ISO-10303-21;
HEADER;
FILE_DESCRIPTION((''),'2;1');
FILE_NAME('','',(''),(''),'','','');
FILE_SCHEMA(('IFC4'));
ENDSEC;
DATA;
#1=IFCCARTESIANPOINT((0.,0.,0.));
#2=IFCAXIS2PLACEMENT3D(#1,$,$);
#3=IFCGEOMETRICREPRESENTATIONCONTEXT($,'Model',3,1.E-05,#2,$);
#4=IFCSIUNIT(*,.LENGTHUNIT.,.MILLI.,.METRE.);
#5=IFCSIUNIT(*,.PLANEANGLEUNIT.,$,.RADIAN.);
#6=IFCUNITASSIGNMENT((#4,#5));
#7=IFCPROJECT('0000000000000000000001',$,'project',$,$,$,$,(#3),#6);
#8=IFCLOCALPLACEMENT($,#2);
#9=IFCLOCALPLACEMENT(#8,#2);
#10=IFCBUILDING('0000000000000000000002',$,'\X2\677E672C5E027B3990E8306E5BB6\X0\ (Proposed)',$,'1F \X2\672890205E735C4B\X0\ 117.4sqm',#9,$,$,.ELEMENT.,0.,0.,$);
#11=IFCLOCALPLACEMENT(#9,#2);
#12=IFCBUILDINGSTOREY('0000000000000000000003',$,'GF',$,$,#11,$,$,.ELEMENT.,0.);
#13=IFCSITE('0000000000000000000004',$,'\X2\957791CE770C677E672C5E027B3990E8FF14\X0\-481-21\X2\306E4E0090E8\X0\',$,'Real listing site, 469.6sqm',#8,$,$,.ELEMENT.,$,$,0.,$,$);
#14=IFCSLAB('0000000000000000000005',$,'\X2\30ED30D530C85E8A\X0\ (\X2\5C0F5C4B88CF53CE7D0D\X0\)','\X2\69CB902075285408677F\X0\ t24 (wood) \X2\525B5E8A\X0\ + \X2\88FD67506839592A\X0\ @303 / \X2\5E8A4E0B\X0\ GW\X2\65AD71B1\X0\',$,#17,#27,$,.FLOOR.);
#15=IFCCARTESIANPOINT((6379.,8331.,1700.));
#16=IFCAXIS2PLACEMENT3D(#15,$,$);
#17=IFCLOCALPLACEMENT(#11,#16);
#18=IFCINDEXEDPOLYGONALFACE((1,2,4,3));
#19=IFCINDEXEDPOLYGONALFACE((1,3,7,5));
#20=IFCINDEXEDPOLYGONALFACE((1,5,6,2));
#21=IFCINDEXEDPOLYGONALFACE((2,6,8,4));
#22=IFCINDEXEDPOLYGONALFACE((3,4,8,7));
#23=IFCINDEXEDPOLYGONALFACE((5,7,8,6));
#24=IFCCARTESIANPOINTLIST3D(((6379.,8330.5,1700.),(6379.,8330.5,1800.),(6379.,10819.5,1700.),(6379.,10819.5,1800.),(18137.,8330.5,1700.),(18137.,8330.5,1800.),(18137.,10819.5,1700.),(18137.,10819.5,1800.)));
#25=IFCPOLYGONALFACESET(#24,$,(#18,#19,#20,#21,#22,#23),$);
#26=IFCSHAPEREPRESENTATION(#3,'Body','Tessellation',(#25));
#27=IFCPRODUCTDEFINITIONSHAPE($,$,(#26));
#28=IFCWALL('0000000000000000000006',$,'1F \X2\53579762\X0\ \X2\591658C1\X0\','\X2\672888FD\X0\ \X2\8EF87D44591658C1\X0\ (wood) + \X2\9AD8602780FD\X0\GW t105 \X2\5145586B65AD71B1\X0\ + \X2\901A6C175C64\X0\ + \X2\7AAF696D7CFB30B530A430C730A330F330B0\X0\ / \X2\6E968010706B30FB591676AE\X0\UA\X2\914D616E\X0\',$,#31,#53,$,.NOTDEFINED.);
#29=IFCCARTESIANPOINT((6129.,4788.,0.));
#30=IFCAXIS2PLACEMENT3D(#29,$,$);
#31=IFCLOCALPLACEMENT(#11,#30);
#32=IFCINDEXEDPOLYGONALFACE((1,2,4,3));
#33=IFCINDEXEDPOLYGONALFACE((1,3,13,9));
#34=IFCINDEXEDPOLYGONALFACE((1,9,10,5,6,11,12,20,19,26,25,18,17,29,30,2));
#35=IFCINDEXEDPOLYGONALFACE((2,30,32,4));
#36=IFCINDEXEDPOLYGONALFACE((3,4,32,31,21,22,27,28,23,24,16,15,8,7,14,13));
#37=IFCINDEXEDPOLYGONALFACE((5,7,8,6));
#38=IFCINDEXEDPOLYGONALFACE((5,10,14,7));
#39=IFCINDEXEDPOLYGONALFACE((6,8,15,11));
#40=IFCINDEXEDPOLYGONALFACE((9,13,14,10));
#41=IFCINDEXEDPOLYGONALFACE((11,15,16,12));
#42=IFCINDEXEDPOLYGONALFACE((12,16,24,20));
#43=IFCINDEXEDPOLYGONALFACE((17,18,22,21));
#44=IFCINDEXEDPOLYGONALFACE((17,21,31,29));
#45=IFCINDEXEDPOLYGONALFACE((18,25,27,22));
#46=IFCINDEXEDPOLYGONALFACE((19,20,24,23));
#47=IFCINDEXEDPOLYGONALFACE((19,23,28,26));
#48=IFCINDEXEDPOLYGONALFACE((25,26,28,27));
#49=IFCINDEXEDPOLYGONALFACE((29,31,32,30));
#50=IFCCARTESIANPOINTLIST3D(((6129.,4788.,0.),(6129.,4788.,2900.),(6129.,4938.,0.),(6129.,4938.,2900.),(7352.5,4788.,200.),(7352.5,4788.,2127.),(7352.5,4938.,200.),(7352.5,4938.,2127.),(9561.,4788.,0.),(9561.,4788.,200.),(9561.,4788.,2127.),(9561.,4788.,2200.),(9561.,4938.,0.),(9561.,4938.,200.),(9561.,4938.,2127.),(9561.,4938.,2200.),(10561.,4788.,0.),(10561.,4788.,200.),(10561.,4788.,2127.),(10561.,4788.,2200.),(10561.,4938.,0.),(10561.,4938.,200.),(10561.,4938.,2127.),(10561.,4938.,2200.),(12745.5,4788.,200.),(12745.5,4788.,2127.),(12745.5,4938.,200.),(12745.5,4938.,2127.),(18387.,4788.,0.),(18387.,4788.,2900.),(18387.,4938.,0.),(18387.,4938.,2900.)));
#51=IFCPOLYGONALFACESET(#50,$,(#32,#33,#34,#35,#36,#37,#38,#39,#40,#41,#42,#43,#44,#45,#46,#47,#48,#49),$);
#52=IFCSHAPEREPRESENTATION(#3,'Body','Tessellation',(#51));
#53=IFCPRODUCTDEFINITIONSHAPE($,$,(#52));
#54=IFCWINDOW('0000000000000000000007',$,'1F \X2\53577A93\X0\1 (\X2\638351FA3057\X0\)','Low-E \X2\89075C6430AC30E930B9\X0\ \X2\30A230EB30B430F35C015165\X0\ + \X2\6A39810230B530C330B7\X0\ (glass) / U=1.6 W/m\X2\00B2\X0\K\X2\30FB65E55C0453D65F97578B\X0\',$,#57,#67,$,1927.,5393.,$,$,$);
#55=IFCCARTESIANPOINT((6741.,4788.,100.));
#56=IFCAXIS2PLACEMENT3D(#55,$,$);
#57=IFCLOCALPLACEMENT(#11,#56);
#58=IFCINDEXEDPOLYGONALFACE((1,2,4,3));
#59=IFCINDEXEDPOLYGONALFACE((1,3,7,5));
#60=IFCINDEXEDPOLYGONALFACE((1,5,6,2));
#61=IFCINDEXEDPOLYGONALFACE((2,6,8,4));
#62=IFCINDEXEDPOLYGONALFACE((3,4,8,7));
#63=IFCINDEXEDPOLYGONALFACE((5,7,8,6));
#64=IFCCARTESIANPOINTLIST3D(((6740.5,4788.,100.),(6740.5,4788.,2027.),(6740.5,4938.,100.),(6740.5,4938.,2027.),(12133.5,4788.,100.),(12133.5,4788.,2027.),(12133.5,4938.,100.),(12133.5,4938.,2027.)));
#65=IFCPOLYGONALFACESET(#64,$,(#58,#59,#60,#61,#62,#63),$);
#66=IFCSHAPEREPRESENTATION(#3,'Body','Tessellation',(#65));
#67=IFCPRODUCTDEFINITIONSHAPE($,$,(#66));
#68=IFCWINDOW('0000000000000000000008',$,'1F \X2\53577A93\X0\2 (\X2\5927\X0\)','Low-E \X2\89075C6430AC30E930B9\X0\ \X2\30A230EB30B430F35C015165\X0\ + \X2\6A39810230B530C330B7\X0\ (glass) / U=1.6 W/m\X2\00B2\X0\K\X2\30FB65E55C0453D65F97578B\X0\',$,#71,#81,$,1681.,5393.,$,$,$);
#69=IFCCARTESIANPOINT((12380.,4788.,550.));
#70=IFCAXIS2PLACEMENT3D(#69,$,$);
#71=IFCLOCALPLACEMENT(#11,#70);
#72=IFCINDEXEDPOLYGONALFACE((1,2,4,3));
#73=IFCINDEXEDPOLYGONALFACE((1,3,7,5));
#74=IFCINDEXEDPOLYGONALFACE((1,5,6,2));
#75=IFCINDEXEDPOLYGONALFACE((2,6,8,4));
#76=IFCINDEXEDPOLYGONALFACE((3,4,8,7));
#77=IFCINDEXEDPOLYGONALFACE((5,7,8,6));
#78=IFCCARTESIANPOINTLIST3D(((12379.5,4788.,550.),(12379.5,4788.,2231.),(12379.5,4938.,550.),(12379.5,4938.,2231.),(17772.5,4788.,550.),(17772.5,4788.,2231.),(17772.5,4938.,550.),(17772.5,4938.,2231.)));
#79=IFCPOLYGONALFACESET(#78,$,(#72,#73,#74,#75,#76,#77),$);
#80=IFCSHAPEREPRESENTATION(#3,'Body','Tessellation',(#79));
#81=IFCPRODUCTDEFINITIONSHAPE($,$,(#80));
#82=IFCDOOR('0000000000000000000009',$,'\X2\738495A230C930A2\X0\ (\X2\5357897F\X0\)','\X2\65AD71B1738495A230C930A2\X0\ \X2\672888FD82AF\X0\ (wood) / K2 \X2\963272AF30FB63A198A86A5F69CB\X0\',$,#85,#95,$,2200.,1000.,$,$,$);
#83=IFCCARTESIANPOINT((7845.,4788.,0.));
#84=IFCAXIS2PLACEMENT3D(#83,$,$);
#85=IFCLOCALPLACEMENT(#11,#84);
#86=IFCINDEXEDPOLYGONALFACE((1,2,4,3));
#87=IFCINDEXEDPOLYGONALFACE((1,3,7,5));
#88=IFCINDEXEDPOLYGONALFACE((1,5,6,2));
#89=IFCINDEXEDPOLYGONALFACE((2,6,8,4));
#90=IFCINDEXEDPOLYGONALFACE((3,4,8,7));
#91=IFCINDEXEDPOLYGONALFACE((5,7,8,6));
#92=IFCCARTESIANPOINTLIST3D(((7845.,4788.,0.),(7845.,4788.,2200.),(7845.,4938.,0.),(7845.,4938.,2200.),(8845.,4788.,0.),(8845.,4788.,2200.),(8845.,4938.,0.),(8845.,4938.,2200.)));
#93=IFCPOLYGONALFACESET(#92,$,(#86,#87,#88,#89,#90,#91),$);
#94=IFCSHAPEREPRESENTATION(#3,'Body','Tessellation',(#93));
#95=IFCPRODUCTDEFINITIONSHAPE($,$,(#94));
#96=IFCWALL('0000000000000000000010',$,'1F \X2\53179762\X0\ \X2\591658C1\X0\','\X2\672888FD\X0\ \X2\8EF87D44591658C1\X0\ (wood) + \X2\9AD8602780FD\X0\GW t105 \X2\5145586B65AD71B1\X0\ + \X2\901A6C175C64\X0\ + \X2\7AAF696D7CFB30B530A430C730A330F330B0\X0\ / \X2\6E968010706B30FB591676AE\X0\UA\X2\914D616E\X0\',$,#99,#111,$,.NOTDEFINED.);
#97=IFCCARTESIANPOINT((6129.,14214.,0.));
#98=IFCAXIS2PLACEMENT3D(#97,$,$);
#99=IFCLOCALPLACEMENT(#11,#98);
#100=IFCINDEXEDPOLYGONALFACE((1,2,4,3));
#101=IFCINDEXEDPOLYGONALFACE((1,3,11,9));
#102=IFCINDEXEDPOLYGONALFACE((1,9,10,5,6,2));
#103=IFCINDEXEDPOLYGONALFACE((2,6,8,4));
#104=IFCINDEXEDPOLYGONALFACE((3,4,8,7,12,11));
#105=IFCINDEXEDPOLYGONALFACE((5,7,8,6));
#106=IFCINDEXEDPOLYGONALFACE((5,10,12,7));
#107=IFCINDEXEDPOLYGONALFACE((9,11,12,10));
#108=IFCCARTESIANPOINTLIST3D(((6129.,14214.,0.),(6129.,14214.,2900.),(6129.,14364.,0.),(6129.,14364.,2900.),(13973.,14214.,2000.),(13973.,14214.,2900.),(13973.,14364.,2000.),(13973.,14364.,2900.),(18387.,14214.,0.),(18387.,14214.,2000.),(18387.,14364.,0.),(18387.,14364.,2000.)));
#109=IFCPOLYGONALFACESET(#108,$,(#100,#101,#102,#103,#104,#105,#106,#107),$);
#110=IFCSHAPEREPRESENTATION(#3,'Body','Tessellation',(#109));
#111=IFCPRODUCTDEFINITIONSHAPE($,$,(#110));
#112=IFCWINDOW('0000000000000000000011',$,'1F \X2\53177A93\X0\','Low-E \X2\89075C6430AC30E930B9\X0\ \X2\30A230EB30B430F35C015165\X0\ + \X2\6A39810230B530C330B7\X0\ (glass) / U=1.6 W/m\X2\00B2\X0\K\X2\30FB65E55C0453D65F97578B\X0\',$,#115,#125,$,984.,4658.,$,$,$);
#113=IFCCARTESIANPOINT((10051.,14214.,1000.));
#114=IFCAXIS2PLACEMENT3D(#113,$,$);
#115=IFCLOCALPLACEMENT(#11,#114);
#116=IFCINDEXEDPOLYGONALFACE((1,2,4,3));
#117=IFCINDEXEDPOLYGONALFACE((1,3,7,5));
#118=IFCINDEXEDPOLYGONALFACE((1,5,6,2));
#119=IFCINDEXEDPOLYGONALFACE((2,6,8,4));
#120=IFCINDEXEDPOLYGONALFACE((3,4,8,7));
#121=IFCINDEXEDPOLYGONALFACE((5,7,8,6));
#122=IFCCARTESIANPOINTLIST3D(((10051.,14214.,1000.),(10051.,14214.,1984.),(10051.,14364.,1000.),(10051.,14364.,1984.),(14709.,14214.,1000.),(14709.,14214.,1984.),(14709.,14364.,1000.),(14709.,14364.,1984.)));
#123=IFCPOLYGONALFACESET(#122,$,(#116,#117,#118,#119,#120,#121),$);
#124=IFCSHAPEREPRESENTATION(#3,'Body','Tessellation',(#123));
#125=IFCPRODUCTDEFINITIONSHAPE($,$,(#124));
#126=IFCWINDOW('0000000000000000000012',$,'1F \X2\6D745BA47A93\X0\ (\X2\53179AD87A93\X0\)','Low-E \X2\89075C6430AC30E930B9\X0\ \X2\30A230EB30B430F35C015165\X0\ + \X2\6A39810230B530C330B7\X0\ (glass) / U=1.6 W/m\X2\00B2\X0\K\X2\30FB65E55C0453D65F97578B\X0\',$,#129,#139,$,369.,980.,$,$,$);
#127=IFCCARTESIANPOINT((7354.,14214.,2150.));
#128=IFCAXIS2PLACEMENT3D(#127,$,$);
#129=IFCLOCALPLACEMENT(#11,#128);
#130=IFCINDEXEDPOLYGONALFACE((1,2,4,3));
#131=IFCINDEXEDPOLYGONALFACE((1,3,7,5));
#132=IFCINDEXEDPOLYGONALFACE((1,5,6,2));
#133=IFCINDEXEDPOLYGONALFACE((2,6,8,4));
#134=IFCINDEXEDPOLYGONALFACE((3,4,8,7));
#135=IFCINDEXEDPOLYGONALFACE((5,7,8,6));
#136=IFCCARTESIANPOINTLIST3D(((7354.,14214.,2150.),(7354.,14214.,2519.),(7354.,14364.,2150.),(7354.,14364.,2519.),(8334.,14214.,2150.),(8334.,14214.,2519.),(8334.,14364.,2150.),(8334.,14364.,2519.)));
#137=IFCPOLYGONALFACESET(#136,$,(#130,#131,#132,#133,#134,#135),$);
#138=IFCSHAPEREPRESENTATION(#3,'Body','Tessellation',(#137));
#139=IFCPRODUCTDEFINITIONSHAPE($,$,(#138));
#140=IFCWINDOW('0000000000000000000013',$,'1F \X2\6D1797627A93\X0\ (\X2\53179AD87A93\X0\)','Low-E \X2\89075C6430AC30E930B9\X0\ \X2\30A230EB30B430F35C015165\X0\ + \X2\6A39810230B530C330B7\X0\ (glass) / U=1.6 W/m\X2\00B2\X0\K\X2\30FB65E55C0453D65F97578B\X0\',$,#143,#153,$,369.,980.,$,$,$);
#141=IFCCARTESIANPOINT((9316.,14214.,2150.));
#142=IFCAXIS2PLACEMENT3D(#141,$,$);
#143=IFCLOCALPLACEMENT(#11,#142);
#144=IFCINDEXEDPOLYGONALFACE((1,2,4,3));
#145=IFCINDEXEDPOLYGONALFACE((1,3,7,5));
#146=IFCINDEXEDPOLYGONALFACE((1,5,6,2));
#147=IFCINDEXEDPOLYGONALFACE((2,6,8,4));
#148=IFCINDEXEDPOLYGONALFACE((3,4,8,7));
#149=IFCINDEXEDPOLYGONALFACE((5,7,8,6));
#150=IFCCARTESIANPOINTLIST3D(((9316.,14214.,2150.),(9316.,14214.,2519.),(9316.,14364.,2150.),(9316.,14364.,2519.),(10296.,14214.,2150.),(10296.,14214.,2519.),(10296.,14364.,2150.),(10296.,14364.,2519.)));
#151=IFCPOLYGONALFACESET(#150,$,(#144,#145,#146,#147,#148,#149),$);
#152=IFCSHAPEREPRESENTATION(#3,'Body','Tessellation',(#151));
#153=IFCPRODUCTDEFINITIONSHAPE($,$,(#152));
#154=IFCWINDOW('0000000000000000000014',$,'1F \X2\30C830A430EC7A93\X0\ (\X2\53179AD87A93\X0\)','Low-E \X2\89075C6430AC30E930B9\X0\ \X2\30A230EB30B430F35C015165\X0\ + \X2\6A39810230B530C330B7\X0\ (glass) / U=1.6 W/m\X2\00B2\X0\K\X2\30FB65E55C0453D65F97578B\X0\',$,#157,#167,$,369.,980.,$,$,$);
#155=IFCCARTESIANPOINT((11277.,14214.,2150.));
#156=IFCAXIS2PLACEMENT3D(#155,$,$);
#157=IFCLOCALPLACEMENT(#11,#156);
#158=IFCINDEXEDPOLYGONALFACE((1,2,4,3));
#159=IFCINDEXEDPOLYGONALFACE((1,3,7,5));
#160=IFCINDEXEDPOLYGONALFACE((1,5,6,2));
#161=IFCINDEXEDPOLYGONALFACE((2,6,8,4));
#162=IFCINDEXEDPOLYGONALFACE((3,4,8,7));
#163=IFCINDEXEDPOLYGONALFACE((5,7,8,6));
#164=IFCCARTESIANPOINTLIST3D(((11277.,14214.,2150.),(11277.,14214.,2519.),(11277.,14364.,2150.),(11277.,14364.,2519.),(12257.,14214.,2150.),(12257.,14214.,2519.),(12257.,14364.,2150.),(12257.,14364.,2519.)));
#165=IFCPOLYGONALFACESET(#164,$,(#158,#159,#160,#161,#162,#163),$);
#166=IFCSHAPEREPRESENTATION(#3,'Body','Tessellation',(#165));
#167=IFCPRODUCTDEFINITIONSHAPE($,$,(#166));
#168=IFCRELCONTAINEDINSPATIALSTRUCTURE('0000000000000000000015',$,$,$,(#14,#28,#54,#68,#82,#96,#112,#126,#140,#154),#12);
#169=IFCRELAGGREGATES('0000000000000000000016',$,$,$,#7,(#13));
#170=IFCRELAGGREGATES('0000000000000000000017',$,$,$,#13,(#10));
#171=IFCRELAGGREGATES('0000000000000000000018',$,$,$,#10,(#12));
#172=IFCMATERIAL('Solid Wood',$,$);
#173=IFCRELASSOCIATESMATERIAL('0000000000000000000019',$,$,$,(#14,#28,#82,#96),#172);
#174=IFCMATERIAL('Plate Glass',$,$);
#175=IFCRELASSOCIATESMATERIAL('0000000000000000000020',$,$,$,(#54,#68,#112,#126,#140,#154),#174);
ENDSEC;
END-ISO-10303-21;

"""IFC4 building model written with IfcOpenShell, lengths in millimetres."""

from ifc_helpers import new_model, si_unit, frame, frame_2d, origin, place, context, project, spatial, rectangle, extrude, material, element, fill, save


model = new_model("IFC4")

# Units and contexts
model_context = context("Model", 3, precision=1e-05, world=origin())
ifc_project = project(units=[si_unit("LENGTHUNIT", "METRE", prefix="MILLI"), si_unit("PLANEANGLEUNIT", "RADIAN")], contexts=[model_context])

# Site, building, storey
site_placement = place(None, origin())
site = spatial("IfcSite", under=ifc_project, at=site_placement, Name="長野県松本市笹部４-481-21の一部", ObjectType="Real listing site, 469.6sqm", CompositionType="ELEMENT", RefElevation=0.0)
building_placement = place(site_placement, origin())
building = spatial("IfcBuilding", under=site, at=building_placement, Name="松本市笹部の家 (Proposed)", ObjectType="1F 木造平屋 117.4sqm", CompositionType="ELEMENT", ElevationOfRefHeight=0.0, ElevationOfTerrain=0.0)
storey_placement = place(building_placement, origin())
storey = spatial("IfcBuildingStorey", under=building, at=storey_placement, Name="GF", CompositionType="ELEMENT", Elevation=0.0)

# Slab
ifc_material_1 = material(Name="Solid Wood")
slab_1_placement = place(storey_placement, frame((6379.0, 8331.0, 1700.0)))
element("IfcSlab", 1, at=slab_1_placement, inside=storey, material=ifc_material_1, Name="ロフト床 (小屋裏収納)", Description="構造用合板 t24 (wood) 剛床 + 製材根太 @303 / 床下 GW断熱", PredefinedType="FLOOR", context=model_context, shape_type="SweptSolid", body=[
    extrude(rectangle(XDim=11758.0, YDim=2489.0, at=frame_2d((5879.0, 1244.0))), frame((6379.0, 8331.0, 1700.0)), (0.0, 0.0, 1.0), 100.0),
])

# Wall, openings, windows, door
wall_1_placement = place(storey_placement, frame((6129.0, 4788.0, 0.0)))
wall_1 = element("IfcWall", 2, at=wall_1_placement, inside=storey, material=ifc_material_1, Name="1F 南面 外壁", Description="木製 軸組外壁 (wood) + 高性能GW t105 充填断熱 + 通気層 + 窯業系サイディング / 準耐火・外皮UA配慮", PredefinedType="NOTDEFINED", context=model_context, shape_type="SweptSolid", body=[
    extrude(rectangle(XDim=12258.0, YDim=150.0, at=frame_2d((6129.0, 75.0))), frame((6129.0, 4788.0, 0.0)), (0.0, 0.0, 1.0), 2900.0),
])
opening_1_placement = place(storey_placement, frame((6741.0, 4788.0, 100.0)))
opening_1 = element("IfcOpeningElement", 3, at=opening_1_placement, cuts=wall_1, PredefinedType="NOTDEFINED", context=model_context, shape_type="SweptSolid", body=[
    extrude(rectangle(XDim=5393.0, YDim=150.0, at=frame_2d((2696.0, 75.0))), frame((6741.0, 4788.0, 100.0)), (0.0, 0.0, 1.0), 1927.0),
])
opening_2_placement = place(storey_placement, frame((12380.0, 4788.0, 550.0)))
opening_2 = element("IfcOpeningElement", 4, at=opening_2_placement, cuts=wall_1, PredefinedType="NOTDEFINED", context=model_context, shape_type="SweptSolid", body=[
    extrude(rectangle(XDim=5393.0, YDim=150.0, at=frame_2d((2696.0, 75.0))), frame((12380.0, 4788.0, 550.0)), (0.0, 0.0, 1.0), 1681.0),
])
opening_3_placement = place(storey_placement, frame((7845.0, 4788.0, 0.0)))
opening_3 = element("IfcOpeningElement", 5, at=opening_3_placement, cuts=wall_1, PredefinedType="NOTDEFINED", context=model_context, shape_type="SweptSolid", body=[
    extrude(rectangle(XDim=1000.0, YDim=150.0, at=frame_2d((500.0, 75.0))), frame((7845.0, 4788.0, 0.0)), (0.0, 0.0, 1.0), 2200.0),
])
ifc_material_2 = material(Name="Plate Glass")
window_1_placement = place(storey_placement, frame((6741.0, 4788.0, 100.0)))
window_1 = element("IfcWindow", 6, at=window_1_placement, inside=storey, material=ifc_material_2, Name="1F 南窓1 (掃出し)", Description="Low-E 複層ガラス アルゴン封入 + 樹脂サッシ (glass) / U=1.6 W/m²K・日射取得型", OverallHeight=1927.0, OverallWidth=5393.0, context=model_context, shape_type="SweptSolid", body=[
    extrude(rectangle(XDim=5393.0, YDim=150.0, at=frame_2d((2696.0, 75.0))), frame((6741.0, 4788.0, 100.0)), (0.0, 0.0, 1.0), 1927.0),
])
fill(opening_1, window_1)
window_2_placement = place(storey_placement, frame((12380.0, 4788.0, 550.0)))
window_2 = element("IfcWindow", 7, at=window_2_placement, inside=storey, material=ifc_material_2, Name="1F 南窓2 (大)", Description="Low-E 複層ガラス アルゴン封入 + 樹脂サッシ (glass) / U=1.6 W/m²K・日射取得型", OverallHeight=1681.0, OverallWidth=5393.0, context=model_context, shape_type="SweptSolid", body=[
    extrude(rectangle(XDim=5393.0, YDim=150.0, at=frame_2d((2696.0, 75.0))), frame((12380.0, 4788.0, 550.0)), (0.0, 0.0, 1.0), 1681.0),
])
fill(opening_2, window_2)
door_1_placement = place(storey_placement, frame((7845.0, 4788.0, 0.0)))
door_1 = element("IfcDoor", 8, at=door_1_placement, inside=storey, material=ifc_material_1, Name="玄関ドア (南西)", Description="断熱玄関ドア 木製芯 (wood) / K2 防犯・採風機構", OverallHeight=2200.0, OverallWidth=1000.0, context=model_context, shape_type="SweptSolid", body=[
    extrude(rectangle(XDim=1000.0, YDim=150.0, at=frame_2d((500.0, 75.0))), frame((7845.0, 4788.0, 0.0)), (0.0, 0.0, 1.0), 2200.0),
])
fill(opening_3, door_1)

# Wall, openings, windows
wall_2_placement = place(storey_placement, frame((6129.0, 14214.0, 0.0)))
wall_2 = element("IfcWall", 9, at=wall_2_placement, inside=storey, material=ifc_material_1, Name="1F 北面 外壁", Description="木製 軸組外壁 (wood) + 高性能GW t105 充填断熱 + 通気層 + 窯業系サイディング / 準耐火・外皮UA配慮", PredefinedType="NOTDEFINED", context=model_context, shape_type="SweptSolid", body=[
    extrude(rectangle(XDim=12258.0, YDim=150.0, at=frame_2d((6129.0, 75.0))), frame((6129.0, 14214.0, 0.0)), (0.0, 0.0, 1.0), 2900.0),
])
opening_4_placement = place(storey_placement, frame((10051.0, 14214.0, 1000.0)))
opening_4 = element("IfcOpeningElement", 10, at=opening_4_placement, cuts=wall_2, PredefinedType="NOTDEFINED", context=model_context, shape_type="SweptSolid", body=[
    extrude(rectangle(XDim=4658.0, YDim=150.0, at=frame_2d((2329.0, 75.0))), frame((10051.0, 14214.0, 1000.0)), (0.0, 0.0, 1.0), 984.0),
])
opening_5_placement = place(storey_placement, frame((7354.0, 14214.0, 2150.0)))
opening_5 = element("IfcOpeningElement", 11, at=opening_5_placement, cuts=wall_2, PredefinedType="NOTDEFINED", context=model_context, shape_type="SweptSolid", body=[
    extrude(rectangle(XDim=980.0, YDim=150.0, at=frame_2d((490.0, 75.0))), frame((7354.0, 14214.0, 2150.0)), (0.0, 0.0, 1.0), 369.0),
])
opening_6_placement = place(storey_placement, frame((9316.0, 14214.0, 2150.0)))
opening_6 = element("IfcOpeningElement", 12, at=opening_6_placement, cuts=wall_2, PredefinedType="NOTDEFINED", context=model_context, shape_type="SweptSolid", body=[
    extrude(rectangle(XDim=980.0, YDim=150.0, at=frame_2d((490.0, 75.0))), frame((9316.0, 14214.0, 2150.0)), (0.0, 0.0, 1.0), 369.0),
])
opening_7_placement = place(storey_placement, frame((11277.0, 14214.0, 2150.0)))
opening_7 = element("IfcOpeningElement", 13, at=opening_7_placement, cuts=wall_2, PredefinedType="NOTDEFINED", context=model_context, shape_type="SweptSolid", body=[
    extrude(rectangle(XDim=980.0, YDim=150.0, at=frame_2d((490.0, 75.0))), frame((11277.0, 14214.0, 2150.0)), (0.0, 0.0, 1.0), 369.0),
])
window_3_placement = place(storey_placement, frame((10051.0, 14214.0, 1000.0)))
window_3 = element("IfcWindow", 14, at=window_3_placement, inside=storey, material=ifc_material_2, Name="1F 北窓", Description="Low-E 複層ガラス アルゴン封入 + 樹脂サッシ (glass) / U=1.6 W/m²K・日射取得型", OverallHeight=984.0, OverallWidth=4658.0, context=model_context, shape_type="SweptSolid", body=[
    extrude(rectangle(XDim=4658.0, YDim=150.0, at=frame_2d((2329.0, 75.0))), frame((10051.0, 14214.0, 1000.0)), (0.0, 0.0, 1.0), 984.0),
])
fill(opening_4, window_3)
window_4_placement = place(storey_placement, frame((7354.0, 14214.0, 2150.0)))
window_4 = element("IfcWindow", 15, at=window_4_placement, inside=storey, material=ifc_material_2, Name="1F 浴室窓 (北高窓)", Description="Low-E 複層ガラス アルゴン封入 + 樹脂サッシ (glass) / U=1.6 W/m²K・日射取得型", OverallHeight=369.0, OverallWidth=980.0, context=model_context, shape_type="SweptSolid", body=[
    extrude(rectangle(XDim=980.0, YDim=150.0, at=frame_2d((490.0, 75.0))), frame((7354.0, 14214.0, 2150.0)), (0.0, 0.0, 1.0), 369.0),
])
fill(opening_5, window_4)
window_5_placement = place(storey_placement, frame((9316.0, 14214.0, 2150.0)))
window_5 = element("IfcWindow", 16, at=window_5_placement, inside=storey, material=ifc_material_2, Name="1F 洗面窓 (北高窓)", Description="Low-E 複層ガラス アルゴン封入 + 樹脂サッシ (glass) / U=1.6 W/m²K・日射取得型", OverallHeight=369.0, OverallWidth=980.0, context=model_context, shape_type="SweptSolid", body=[
    extrude(rectangle(XDim=980.0, YDim=150.0, at=frame_2d((490.0, 75.0))), frame((9316.0, 14214.0, 2150.0)), (0.0, 0.0, 1.0), 369.0),
])
fill(opening_6, window_5)
window_6_placement = place(storey_placement, frame((11277.0, 14214.0, 2150.0)))
window_6 = element("IfcWindow", 17, at=window_6_placement, inside=storey, material=ifc_material_2, Name="1F トイレ窓 (北高窓)", Description="Low-E 複層ガラス アルゴン封入 + 樹脂サッシ (glass) / U=1.6 W/m²K・日射取得型", OverallHeight=369.0, OverallWidth=980.0, context=model_context, shape_type="SweptSolid", body=[
    extrude(rectangle(XDim=980.0, YDim=150.0, at=frame_2d((490.0, 75.0))), frame((11277.0, 14214.0, 2150.0)), (0.0, 0.0, 1.0), 369.0),
])
fill(opening_7, window_6)

save(model, "model.ifc")
